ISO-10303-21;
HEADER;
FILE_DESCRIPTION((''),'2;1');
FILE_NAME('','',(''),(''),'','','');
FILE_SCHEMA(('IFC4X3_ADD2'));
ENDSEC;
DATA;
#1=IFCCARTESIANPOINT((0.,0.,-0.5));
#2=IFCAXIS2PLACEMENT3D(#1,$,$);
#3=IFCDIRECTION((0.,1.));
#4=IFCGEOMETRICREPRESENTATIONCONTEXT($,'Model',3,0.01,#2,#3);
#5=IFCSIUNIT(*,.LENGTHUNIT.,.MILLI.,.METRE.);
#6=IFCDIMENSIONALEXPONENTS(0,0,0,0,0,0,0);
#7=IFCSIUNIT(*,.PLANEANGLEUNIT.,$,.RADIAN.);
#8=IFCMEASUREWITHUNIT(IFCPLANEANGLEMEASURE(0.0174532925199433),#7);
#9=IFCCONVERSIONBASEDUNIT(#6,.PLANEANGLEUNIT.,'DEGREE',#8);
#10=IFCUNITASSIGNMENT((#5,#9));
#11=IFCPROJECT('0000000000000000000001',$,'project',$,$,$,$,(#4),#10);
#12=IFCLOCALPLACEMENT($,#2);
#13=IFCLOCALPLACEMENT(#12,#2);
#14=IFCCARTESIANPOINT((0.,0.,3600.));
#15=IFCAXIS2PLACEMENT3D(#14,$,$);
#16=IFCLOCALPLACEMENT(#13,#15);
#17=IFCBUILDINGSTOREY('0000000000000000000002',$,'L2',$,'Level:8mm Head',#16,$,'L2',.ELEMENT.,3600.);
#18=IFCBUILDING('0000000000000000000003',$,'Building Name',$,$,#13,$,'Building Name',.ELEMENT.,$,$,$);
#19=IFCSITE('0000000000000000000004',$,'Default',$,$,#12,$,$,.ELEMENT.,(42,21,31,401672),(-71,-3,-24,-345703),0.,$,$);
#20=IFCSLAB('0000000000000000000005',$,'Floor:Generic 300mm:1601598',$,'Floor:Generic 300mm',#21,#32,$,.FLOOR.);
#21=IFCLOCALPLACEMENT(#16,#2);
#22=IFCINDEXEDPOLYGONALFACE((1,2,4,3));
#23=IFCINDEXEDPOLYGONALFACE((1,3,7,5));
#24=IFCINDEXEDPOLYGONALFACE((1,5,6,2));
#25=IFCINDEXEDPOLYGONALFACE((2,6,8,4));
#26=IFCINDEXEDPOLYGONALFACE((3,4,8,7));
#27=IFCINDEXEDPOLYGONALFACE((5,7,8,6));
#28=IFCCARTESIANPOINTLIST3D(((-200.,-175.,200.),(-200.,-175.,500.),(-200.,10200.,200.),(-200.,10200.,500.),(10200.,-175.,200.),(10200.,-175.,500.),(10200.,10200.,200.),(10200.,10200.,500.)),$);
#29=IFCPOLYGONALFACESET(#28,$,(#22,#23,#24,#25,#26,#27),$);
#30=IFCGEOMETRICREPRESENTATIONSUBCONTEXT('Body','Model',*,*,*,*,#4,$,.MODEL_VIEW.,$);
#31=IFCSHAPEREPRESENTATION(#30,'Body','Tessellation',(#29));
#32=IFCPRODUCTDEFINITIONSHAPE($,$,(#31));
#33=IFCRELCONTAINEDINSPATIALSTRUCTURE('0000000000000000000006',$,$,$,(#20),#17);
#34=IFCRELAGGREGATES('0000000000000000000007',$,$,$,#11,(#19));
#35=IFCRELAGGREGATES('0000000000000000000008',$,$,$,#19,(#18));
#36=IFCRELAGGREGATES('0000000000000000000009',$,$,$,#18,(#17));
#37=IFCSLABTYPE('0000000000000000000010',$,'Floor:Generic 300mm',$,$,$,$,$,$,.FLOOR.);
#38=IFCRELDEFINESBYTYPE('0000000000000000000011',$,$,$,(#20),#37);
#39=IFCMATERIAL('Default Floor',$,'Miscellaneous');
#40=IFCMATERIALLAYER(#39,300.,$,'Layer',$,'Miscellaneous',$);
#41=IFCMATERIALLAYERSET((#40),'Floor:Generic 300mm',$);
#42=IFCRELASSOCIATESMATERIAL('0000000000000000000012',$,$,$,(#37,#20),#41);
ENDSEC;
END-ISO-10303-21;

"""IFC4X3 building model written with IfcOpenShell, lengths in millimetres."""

from ifc_helpers import new_model, entity, si_unit, converted_unit, direction, frame, frame_2d, place, context, subcontext, project, spatial, rectangle, extrude, material, layer, layer_set, layer_usage, type_object, element, save


model = new_model("IFC4X3")

# Units and contexts
model_context = context("Model", 3, precision=0.01, world=frame((0.0, 0.0, -0.5)), true_north=direction((0.0, 1.0)))
body_context = subcontext(model_context, "Body", "Model", "MODEL_VIEW")
ifc_project = project(units=[si_unit("LENGTHUNIT", "METRE", prefix="MILLI"), converted_unit("PLANEANGLEUNIT", "DEGREE", entity("IfcPlaneAngleMeasure", 0.0174532925199433), si_unit("PLANEANGLEUNIT", "RADIAN"), dimensions=[0, 0, 0, 0, 0, 0, 0])], contexts=[model_context])

# Site, building, storey
site_placement = place(None, frame((0.0, 0.0, -0.5)))
site = spatial("IfcSite", under=ifc_project, at=site_placement, Name="Default", CompositionType="ELEMENT", RefLatitude=(42, 21, 31, 401672), RefLongitude=(-71, -3, -24, -345703), RefElevation=0.0)
building_placement = place(site_placement, frame((0.0, 0.0, -0.5)))
building = spatial("IfcBuilding", under=site, at=building_placement, Name="Building Name", LongName="Building Name", CompositionType="ELEMENT")
storey_placement = place(building_placement, frame((0.0, 0.0, 3600.0)))
storey = spatial("IfcBuildingStorey", under=building, at=storey_placement, Name="L2", ObjectType="Level:8mm Head", LongName="L2", CompositionType="ELEMENT", Elevation=3600.0)

# Slab
ifc_material = material(Name="Default Floor", Category="Miscellaneous")
ifc_layer = layer(ifc_material, 300.0, Name="Layer", Category="Miscellaneous")
ifc_layer_set = layer_set([ifc_layer], Name="Floor:Generic 300mm")
ifc_layer_usage = layer_usage(ifc_layer_set, "AXIS3", "POSITIVE", 0.0)
slab_type = type_object("IfcSlabType", Name="Floor:Generic 300mm", PredefinedType="FLOOR", material=ifc_layer_set)
slab_placement = place(storey_placement, frame((0.0, 0.0, -0.5)))
element("IfcSlab", 1, at=slab_placement, inside=storey, type_object=slab_type, material=ifc_layer_usage, Name="Floor:Generic 300mm:1601598", ObjectType="Floor:Generic 300mm", PredefinedType="FLOOR", context=body_context, shape_type="SweptSolid", body=[
    extrude(rectangle(XDim=10375.0, YDim=10400.0, at=frame_2d((0.0, 0.0), x_axis=(1.0, 0.0))), frame((5000.0, 5012.5, 500.0), z_axis=(0.0, 0.0, -1.0), x_axis=(0.0, 1.0, 0.0)), (0.0, 0.0, 1.0), 300.0),
])

save(model, "model.ifc")
